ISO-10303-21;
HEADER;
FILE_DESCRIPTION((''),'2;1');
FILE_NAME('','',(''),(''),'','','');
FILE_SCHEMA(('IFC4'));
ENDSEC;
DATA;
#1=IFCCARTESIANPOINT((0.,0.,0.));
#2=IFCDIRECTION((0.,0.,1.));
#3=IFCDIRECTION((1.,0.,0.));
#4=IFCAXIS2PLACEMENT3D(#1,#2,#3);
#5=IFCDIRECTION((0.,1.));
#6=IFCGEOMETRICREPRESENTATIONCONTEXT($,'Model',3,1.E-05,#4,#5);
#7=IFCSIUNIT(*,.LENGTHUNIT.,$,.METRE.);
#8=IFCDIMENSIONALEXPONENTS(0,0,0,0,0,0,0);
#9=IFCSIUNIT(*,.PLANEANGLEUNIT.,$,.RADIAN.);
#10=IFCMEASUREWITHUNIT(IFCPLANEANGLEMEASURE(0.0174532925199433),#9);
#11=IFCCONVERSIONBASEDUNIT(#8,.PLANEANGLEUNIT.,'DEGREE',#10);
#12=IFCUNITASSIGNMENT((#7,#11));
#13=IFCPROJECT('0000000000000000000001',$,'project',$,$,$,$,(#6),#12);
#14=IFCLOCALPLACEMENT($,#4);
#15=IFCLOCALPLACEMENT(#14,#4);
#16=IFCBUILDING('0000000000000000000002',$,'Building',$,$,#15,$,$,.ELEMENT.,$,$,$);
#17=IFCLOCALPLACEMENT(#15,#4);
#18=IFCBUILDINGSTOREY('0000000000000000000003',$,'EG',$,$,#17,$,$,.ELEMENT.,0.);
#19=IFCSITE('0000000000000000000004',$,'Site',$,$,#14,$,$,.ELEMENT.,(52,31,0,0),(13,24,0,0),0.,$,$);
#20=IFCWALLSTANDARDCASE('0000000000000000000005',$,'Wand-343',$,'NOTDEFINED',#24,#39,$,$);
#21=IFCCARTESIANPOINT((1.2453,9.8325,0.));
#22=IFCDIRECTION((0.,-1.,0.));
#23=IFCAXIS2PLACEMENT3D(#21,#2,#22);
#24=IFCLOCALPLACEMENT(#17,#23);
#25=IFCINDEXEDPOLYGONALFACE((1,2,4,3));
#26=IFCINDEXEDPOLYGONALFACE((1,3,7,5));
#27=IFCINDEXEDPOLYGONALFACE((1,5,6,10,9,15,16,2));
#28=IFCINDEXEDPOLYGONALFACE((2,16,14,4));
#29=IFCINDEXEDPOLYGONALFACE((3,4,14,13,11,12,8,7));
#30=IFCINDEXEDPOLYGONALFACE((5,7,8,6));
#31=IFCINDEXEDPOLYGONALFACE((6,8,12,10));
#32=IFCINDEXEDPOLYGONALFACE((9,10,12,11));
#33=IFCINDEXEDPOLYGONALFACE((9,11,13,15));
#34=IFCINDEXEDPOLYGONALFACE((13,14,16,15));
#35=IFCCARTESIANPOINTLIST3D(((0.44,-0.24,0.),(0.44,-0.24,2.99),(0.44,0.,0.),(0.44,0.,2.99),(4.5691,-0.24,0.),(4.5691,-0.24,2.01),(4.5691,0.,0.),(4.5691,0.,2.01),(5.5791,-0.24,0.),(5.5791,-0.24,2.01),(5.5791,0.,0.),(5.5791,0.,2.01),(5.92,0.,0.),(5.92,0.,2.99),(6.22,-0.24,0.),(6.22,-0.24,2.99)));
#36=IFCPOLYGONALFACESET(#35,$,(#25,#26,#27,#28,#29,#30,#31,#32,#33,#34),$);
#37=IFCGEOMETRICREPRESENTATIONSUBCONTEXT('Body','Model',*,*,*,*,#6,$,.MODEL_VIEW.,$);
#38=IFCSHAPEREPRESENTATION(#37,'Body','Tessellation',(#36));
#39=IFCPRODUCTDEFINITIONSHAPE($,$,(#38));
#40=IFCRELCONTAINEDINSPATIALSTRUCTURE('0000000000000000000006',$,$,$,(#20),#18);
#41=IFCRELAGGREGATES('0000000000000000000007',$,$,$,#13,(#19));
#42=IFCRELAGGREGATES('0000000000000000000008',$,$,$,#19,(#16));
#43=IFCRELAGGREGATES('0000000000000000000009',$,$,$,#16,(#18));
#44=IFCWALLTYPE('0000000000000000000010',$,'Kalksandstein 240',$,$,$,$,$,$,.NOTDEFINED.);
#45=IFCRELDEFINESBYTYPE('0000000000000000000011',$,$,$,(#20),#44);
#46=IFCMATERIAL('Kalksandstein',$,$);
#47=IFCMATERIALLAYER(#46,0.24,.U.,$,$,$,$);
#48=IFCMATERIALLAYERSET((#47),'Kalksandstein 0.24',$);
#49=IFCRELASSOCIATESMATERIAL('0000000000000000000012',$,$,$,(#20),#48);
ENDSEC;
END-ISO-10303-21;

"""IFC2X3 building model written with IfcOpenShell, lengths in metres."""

from ifc_helpers import new_model, entity, si_unit, converted_unit, direction, frame, origin_with_axes, origin_2d_with_axis, place, context, subcontext, project, spatial, polyline, rectangle, outline, extrude, material, layer, layer_set, layer_usage, type_object, element, save


model = new_model("IFC2X3")

# Units and contexts
model_context = context("Model", 3, precision=1e-05, world=origin_with_axes(), true_north=direction((0.0, 1.0)))
body_context = subcontext(model_context, "Body", "Model", "MODEL_VIEW")
ifc_project = project(units=[si_unit("LENGTHUNIT", "METRE"), converted_unit("PLANEANGLEUNIT", "DEGREE", entity("IfcPlaneAngleMeasure", 0.0174532925199433), si_unit("PLANEANGLEUNIT", "RADIAN"), dimensions=[0, 0, 0, 0, 0, 0, 0])], contexts=[model_context])

# Site, building, storey
site_placement = place(None, origin_with_axes())
site = spatial("IfcSite", under=ifc_project, at=site_placement, Name="Site", CompositionType="ELEMENT", RefLatitude=(52, 31, 0, 0), RefLongitude=(13, 24, 0, 0), RefElevation=0.0)
building_placement = place(site_placement, origin_with_axes())
building = spatial("IfcBuilding", under=site, at=building_placement, Name="Building", CompositionType="ELEMENT")
storey_placement = place(building_placement, origin_with_axes())
storey = spatial("IfcBuildingStorey", under=building, at=storey_placement, Name="EG", CompositionType="ELEMENT", Elevation=0.0)

# Shared definitions
ifc_material = material(Name="Kalksandstein")

# Wall, opening
ifc_layer_1 = layer(ifc_material, 0.24, ventilated="UNKNOWN")
ifc_layer_set_1 = layer_set([ifc_layer_1], Name="Kalksandstein 0.24")
ifc_layer_usage_1 = layer_usage(ifc_layer_set_1, "AXIS2", "POSITIVE", -0.24)
wall_type_1 = type_object("IfcWallType", Name="Kalksandstein 240", PredefinedType="NOTDEFINED")
wall_1_placement = place(storey_placement, frame((1.2453, 9.8325, 0.0), z_axis=(0.0, 0.0, 1.0), x_axis=(0.0, -1.0, 0.0)))
wall_1 = element("IfcWallStandardCase", 1, at=wall_1_placement, inside=storey, type_object=wall_type_1, material=ifc_layer_usage_1, Name="Wand-343", ObjectType="NOTDEFINED", context=body_context, shape_type="SweptSolid", body=[
    extrude(outline(polyline([(0.44, -0.24), (6.22, -0.24), (5.92, 0.0), (0.44, 0.0), (0.44, -0.24)])), origin_with_axes(), (0.0, 0.0, 1.0), 2.99),
])
opening_1_placement = place(wall_1_placement, frame((5.0741, 0.0, 0.0), z_axis=(0.0, 0.0, 1.0), x_axis=(1.0, 0.0, 0.0)))
element("IfcOpeningElement", 2, at=opening_1_placement, cuts=wall_1, context=body_context, shape_type="SweptSolid", body=[
    extrude(rectangle(XDim=1.01, YDim=2.01, at=origin_2d_with_axis()), frame((0.0, -0.24, 1.005), z_axis=(0.0, -1.0, 0.0), x_axis=(-1.0, 0.0, 0.0)), (0.0, 0.0, -1.0), 0.72),
])

save(model, "model.ifc")
